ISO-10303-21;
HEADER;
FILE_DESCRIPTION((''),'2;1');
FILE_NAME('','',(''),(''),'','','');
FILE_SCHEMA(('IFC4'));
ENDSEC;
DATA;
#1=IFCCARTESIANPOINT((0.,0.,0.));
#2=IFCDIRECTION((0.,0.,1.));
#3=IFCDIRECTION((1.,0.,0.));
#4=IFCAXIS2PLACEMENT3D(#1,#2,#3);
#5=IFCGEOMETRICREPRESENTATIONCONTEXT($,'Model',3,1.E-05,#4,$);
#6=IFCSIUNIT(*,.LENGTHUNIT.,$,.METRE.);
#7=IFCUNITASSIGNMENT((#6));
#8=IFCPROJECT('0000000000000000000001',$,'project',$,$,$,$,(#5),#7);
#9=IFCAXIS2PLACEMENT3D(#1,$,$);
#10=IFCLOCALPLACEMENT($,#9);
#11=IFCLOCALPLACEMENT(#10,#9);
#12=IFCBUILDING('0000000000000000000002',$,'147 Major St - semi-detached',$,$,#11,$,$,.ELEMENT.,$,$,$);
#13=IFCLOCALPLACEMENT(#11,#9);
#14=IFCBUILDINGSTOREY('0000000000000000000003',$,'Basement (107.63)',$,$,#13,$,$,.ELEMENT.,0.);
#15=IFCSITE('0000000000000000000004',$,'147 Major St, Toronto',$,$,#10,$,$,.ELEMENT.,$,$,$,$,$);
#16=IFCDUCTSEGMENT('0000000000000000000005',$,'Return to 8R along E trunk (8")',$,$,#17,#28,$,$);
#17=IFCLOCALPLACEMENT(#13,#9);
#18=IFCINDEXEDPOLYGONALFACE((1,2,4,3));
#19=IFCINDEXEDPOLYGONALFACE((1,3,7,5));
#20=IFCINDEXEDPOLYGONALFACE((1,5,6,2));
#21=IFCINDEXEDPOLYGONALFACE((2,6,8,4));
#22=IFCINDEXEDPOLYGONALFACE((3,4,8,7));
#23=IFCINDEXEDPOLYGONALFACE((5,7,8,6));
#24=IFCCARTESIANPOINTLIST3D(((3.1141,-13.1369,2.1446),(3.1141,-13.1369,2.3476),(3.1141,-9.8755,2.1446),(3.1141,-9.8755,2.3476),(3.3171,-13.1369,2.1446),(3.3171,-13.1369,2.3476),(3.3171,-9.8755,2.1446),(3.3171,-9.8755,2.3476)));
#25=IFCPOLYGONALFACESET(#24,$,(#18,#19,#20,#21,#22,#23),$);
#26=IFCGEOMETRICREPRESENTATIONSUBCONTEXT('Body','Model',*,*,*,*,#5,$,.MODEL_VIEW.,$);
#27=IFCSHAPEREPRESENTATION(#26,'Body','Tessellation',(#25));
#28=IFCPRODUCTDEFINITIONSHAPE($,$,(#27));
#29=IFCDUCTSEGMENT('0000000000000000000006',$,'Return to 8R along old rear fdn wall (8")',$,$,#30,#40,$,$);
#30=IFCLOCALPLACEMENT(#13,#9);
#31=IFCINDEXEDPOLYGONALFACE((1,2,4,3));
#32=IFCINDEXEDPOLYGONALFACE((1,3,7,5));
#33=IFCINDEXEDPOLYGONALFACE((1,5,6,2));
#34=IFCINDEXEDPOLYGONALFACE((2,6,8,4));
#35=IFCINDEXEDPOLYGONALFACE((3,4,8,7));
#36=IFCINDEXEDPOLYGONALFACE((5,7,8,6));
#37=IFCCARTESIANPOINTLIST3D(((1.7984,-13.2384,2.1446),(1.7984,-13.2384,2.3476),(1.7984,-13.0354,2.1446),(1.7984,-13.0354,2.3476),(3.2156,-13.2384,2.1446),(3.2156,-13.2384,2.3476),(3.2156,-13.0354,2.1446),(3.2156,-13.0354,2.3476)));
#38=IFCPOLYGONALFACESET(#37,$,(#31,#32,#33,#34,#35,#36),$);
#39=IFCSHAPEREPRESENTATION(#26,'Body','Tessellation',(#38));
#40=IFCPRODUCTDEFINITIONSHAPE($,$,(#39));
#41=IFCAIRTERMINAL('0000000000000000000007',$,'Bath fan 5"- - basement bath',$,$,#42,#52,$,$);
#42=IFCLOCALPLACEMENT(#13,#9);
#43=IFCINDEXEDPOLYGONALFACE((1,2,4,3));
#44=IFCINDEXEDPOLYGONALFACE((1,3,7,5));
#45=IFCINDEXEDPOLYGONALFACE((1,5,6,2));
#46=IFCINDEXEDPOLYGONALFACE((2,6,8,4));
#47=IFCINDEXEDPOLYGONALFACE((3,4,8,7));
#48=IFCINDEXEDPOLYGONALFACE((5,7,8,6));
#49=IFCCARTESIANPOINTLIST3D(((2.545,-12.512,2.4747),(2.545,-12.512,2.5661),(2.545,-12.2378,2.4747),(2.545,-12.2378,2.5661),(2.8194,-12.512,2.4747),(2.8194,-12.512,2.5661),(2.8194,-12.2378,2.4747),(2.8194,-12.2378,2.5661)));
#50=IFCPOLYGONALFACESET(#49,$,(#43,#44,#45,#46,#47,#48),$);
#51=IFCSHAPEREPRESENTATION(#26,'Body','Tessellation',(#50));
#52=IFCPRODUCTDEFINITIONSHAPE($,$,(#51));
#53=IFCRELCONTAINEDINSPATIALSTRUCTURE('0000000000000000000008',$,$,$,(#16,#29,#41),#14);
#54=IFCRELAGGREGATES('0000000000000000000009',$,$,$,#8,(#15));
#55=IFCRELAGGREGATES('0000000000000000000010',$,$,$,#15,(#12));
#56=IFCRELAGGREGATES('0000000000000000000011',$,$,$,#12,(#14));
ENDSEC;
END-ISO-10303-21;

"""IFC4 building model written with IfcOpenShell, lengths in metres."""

from ifc_helpers import new_model, si_unit, frame, origin, origin_with_axes, place, context, subcontext, project, spatial, rectangle, extrude, element, save


model = new_model("IFC4")

# Units and contexts
model_context = context("Model", 3, precision=1e-05, world=origin_with_axes())
body_context = subcontext(model_context, "Body", "Model", "MODEL_VIEW")
ifc_project = project(units=[si_unit("LENGTHUNIT", "METRE")], contexts=[model_context])

# Site, building, storey
site_placement = place(None, origin())
site = spatial("IfcSite", under=ifc_project, at=site_placement, Name="147 Major St, Toronto", CompositionType="ELEMENT")
building_placement = place(site_placement, origin())
building = spatial("IfcBuilding", under=site, at=building_placement, Name="147 Major St - semi-detached", CompositionType="ELEMENT")
storey_placement = place(building_placement, origin())
storey = spatial("IfcBuildingStorey", under=building, at=storey_placement, Name="Basement (107.63)", CompositionType="ELEMENT", Elevation=0.0)

# Duct segments
duct_segment_1_placement = place(storey_placement, frame((3.2156, -11.5062, 2.1446)))
element("IfcDuctSegment", 1, at=duct_segment_1_placement, inside=storey, Name="Return to 8R along E trunk (8\")", context=body_context, shape_type="SweptSolid", body=[
    extrude(rectangle(XDim=0.203, YDim=3.2614), origin_with_axes(), (0.0, 0.0, 1.0), 0.203),
])
duct_segment_2_placement = place(storey_placement, frame((2.507, -13.1369, 2.1446)))
element("IfcDuctSegment", 2, at=duct_segment_2_placement, inside=storey, Name="Return to 8R along old rear fdn wall (8\")", context=body_context, shape_type="SweptSolid", body=[
    extrude(rectangle(XDim=1.4173, YDim=0.203), origin_with_axes(), (0.0, 0.0, 1.0), 0.203),
])

# Air terminal
air_terminal_1_placement = place(storey_placement, frame((2.6822, -12.3749, 2.4747)))
element("IfcAirTerminal", 3, at=air_terminal_1_placement, inside=storey, Name="Bath fan 5\"- - basement bath", context=body_context, shape_type="SweptSolid", body=[
    extrude(rectangle(XDim=0.2743, YDim=0.2743), origin_with_axes(), (0.0, 0.0, 1.0), 0.0914),
])

save(model, "model.ifc")
